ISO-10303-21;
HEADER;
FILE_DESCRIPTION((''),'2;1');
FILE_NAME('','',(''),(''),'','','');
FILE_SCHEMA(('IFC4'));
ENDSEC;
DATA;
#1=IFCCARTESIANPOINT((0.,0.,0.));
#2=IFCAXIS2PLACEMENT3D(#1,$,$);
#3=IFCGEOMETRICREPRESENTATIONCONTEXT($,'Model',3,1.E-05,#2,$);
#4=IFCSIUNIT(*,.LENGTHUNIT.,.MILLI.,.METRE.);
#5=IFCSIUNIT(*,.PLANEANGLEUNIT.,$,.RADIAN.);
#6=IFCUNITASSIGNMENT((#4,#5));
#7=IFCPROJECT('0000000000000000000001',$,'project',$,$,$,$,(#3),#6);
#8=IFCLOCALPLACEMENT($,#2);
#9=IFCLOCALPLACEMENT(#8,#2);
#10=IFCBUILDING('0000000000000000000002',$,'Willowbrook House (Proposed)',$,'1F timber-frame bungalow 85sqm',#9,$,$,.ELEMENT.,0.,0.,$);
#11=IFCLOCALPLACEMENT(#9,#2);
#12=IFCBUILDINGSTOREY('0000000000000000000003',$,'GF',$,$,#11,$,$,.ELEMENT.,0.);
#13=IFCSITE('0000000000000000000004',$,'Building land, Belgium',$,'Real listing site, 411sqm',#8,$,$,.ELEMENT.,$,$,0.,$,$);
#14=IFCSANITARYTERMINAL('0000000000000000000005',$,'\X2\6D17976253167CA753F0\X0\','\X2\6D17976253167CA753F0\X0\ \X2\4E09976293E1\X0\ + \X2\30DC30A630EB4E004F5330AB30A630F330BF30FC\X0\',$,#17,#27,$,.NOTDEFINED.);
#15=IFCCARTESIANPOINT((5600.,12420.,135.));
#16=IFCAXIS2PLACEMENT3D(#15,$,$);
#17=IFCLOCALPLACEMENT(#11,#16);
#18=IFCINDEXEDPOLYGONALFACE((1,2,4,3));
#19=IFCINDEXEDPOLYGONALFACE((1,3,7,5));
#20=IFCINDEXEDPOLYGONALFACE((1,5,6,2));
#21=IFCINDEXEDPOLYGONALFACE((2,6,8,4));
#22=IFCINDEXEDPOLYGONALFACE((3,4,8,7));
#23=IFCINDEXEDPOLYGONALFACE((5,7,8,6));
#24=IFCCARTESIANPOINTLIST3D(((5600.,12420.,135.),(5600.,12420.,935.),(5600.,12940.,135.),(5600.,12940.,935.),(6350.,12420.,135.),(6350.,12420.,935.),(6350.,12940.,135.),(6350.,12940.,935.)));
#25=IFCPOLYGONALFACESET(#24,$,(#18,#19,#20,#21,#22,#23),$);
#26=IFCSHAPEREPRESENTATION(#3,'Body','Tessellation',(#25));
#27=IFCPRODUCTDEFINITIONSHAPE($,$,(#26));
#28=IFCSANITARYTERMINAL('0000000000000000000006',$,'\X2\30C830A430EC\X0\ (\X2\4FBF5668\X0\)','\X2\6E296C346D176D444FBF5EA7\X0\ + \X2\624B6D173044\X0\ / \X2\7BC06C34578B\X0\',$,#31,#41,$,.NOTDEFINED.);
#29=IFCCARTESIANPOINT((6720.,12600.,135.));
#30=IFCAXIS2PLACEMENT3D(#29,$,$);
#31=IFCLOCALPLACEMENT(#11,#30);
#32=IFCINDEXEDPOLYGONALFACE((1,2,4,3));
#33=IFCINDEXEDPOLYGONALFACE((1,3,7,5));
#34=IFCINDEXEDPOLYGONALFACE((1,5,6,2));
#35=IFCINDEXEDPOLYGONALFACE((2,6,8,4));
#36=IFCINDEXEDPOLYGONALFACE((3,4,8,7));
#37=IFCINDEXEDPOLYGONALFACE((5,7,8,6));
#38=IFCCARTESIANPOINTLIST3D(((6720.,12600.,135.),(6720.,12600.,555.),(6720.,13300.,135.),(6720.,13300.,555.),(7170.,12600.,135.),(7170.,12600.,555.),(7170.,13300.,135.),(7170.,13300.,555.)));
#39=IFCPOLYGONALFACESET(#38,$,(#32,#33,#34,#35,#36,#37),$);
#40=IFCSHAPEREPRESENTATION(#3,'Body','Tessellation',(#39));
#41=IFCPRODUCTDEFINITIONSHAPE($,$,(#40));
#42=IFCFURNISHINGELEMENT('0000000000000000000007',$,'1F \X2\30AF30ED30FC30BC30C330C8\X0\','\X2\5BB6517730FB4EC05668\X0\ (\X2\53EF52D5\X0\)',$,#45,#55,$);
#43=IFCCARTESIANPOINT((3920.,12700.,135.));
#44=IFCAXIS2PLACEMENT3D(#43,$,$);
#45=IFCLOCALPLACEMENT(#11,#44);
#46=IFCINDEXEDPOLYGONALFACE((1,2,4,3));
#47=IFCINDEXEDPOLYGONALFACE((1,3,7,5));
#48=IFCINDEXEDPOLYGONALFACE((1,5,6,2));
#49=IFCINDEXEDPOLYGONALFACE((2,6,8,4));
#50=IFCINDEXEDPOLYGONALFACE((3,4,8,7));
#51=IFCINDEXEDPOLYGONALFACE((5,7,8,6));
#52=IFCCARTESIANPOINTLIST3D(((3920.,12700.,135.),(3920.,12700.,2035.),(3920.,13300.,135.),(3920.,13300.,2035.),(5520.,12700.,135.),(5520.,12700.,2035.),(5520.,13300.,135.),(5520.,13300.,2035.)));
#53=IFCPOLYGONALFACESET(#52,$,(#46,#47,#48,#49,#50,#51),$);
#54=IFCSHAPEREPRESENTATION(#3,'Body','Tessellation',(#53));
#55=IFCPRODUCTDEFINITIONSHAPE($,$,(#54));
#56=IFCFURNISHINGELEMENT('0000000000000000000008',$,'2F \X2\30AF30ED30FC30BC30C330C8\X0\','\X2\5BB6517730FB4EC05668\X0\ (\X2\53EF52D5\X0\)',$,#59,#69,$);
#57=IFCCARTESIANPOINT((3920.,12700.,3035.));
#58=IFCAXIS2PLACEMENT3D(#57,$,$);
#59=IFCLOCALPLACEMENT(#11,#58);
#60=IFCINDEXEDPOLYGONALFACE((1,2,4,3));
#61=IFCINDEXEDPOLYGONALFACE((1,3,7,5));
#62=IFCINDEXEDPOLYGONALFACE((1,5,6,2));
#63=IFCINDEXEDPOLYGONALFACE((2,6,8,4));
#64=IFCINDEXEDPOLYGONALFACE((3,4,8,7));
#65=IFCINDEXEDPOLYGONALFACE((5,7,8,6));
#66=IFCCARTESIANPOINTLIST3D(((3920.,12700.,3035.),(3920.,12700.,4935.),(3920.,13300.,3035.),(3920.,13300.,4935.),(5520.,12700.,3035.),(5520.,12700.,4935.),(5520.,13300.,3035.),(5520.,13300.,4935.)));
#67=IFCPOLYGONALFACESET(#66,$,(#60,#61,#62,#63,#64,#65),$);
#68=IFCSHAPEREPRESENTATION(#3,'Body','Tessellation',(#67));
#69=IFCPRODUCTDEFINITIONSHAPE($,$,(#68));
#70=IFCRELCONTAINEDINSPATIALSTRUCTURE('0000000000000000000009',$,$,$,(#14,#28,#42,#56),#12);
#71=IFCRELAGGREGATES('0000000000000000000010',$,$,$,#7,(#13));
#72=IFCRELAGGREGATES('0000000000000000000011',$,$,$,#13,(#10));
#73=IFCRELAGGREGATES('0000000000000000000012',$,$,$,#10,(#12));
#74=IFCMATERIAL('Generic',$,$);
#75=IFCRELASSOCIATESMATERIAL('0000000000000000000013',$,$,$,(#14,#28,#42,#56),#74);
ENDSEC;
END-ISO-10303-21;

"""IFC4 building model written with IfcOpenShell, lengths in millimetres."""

from ifc_helpers import new_model, si_unit, frame, frame_2d, origin, place, context, project, spatial, rectangle, extrude, material, element, save


model = new_model("IFC4")

# Units and contexts
model_context = context("Model", 3, precision=1e-05, world=origin())
ifc_project = project(units=[si_unit("LENGTHUNIT", "METRE", prefix="MILLI"), si_unit("PLANEANGLEUNIT", "RADIAN")], contexts=[model_context])

# Site, building, storey
site_placement = place(None, origin())
site = spatial("IfcSite", under=ifc_project, at=site_placement, Name="Building land, Belgium", ObjectType="Real listing site, 411sqm", CompositionType="ELEMENT", RefElevation=0.0)
building_placement = place(site_placement, origin())
building = spatial("IfcBuilding", under=site, at=building_placement, Name="Willowbrook House (Proposed)", ObjectType="1F timber-frame bungalow 85sqm", CompositionType="ELEMENT", ElevationOfRefHeight=0.0, ElevationOfTerrain=0.0)
storey_placement = place(building_placement, origin())
storey = spatial("IfcBuildingStorey", under=building, at=storey_placement, Name="GF", CompositionType="ELEMENT", Elevation=0.0)

# Shared definitions
ifc_material_1 = material(Name="Generic")

# Sanitary terminals
sanitary_terminal_1_placement = place(storey_placement, frame((5600.0, 12420.0, 135.0)))
element("IfcSanitaryTerminal", 1, at=sanitary_terminal_1_placement, inside=storey, material=ifc_material_1, Name="洗面化粧台", Description="洗面化粧台 三面鏡 + ボウル一体カウンター", PredefinedType="NOTDEFINED", context=model_context, shape_type="SweptSolid", body=[
    extrude(rectangle(XDim=750.0, YDim=520.0, at=frame_2d((375.0, 260.0))), frame((5600.0, 12420.0, 135.0)), (0.0, 0.0, 1.0), 800.0),
])
sanitary_terminal_2_placement = place(storey_placement, frame((6720.0, 12600.0, 135.0)))
element("IfcSanitaryTerminal", 2, at=sanitary_terminal_2_placement, inside=storey, material=ifc_material_1, Name="トイレ (便器)", Description="温水洗浄便座 + 手洗い / 節水型", PredefinedType="NOTDEFINED", context=model_context, shape_type="SweptSolid", body=[
    extrude(rectangle(XDim=450.0, YDim=700.0, at=frame_2d((225.0, 350.0))), frame((6720.0, 12600.0, 135.0)), (0.0, 0.0, 1.0), 420.0),
])

# Furnishing elements
furnishing_1_placement = place(storey_placement, frame((3920.0, 12700.0, 135.0)))
element("IfcFurnishingElement", 3, at=furnishing_1_placement, inside=storey, material=ifc_material_1, Name="1F クローゼット", Description="家具・什器 (可動)", context=model_context, shape_type="SweptSolid", body=[
    extrude(rectangle(XDim=1600.0, YDim=600.0, at=frame_2d((800.0, 300.0))), frame((3920.0, 12700.0, 135.0)), (0.0, 0.0, 1.0), 1900.0),
])
furnishing_2_placement = place(storey_placement, frame((3920.0, 12700.0, 3035.0)))
element("IfcFurnishingElement", 4, at=furnishing_2_placement, inside=storey, material=ifc_material_1, Name="2F クローゼット", Description="家具・什器 (可動)", context=model_context, shape_type="SweptSolid", body=[
    extrude(rectangle(XDim=1600.0, YDim=600.0, at=frame_2d((800.0, 300.0))), frame((3920.0, 12700.0, 3035.0)), (0.0, 0.0, 1.0), 1900.0),
])

save(model, "model.ifc")
